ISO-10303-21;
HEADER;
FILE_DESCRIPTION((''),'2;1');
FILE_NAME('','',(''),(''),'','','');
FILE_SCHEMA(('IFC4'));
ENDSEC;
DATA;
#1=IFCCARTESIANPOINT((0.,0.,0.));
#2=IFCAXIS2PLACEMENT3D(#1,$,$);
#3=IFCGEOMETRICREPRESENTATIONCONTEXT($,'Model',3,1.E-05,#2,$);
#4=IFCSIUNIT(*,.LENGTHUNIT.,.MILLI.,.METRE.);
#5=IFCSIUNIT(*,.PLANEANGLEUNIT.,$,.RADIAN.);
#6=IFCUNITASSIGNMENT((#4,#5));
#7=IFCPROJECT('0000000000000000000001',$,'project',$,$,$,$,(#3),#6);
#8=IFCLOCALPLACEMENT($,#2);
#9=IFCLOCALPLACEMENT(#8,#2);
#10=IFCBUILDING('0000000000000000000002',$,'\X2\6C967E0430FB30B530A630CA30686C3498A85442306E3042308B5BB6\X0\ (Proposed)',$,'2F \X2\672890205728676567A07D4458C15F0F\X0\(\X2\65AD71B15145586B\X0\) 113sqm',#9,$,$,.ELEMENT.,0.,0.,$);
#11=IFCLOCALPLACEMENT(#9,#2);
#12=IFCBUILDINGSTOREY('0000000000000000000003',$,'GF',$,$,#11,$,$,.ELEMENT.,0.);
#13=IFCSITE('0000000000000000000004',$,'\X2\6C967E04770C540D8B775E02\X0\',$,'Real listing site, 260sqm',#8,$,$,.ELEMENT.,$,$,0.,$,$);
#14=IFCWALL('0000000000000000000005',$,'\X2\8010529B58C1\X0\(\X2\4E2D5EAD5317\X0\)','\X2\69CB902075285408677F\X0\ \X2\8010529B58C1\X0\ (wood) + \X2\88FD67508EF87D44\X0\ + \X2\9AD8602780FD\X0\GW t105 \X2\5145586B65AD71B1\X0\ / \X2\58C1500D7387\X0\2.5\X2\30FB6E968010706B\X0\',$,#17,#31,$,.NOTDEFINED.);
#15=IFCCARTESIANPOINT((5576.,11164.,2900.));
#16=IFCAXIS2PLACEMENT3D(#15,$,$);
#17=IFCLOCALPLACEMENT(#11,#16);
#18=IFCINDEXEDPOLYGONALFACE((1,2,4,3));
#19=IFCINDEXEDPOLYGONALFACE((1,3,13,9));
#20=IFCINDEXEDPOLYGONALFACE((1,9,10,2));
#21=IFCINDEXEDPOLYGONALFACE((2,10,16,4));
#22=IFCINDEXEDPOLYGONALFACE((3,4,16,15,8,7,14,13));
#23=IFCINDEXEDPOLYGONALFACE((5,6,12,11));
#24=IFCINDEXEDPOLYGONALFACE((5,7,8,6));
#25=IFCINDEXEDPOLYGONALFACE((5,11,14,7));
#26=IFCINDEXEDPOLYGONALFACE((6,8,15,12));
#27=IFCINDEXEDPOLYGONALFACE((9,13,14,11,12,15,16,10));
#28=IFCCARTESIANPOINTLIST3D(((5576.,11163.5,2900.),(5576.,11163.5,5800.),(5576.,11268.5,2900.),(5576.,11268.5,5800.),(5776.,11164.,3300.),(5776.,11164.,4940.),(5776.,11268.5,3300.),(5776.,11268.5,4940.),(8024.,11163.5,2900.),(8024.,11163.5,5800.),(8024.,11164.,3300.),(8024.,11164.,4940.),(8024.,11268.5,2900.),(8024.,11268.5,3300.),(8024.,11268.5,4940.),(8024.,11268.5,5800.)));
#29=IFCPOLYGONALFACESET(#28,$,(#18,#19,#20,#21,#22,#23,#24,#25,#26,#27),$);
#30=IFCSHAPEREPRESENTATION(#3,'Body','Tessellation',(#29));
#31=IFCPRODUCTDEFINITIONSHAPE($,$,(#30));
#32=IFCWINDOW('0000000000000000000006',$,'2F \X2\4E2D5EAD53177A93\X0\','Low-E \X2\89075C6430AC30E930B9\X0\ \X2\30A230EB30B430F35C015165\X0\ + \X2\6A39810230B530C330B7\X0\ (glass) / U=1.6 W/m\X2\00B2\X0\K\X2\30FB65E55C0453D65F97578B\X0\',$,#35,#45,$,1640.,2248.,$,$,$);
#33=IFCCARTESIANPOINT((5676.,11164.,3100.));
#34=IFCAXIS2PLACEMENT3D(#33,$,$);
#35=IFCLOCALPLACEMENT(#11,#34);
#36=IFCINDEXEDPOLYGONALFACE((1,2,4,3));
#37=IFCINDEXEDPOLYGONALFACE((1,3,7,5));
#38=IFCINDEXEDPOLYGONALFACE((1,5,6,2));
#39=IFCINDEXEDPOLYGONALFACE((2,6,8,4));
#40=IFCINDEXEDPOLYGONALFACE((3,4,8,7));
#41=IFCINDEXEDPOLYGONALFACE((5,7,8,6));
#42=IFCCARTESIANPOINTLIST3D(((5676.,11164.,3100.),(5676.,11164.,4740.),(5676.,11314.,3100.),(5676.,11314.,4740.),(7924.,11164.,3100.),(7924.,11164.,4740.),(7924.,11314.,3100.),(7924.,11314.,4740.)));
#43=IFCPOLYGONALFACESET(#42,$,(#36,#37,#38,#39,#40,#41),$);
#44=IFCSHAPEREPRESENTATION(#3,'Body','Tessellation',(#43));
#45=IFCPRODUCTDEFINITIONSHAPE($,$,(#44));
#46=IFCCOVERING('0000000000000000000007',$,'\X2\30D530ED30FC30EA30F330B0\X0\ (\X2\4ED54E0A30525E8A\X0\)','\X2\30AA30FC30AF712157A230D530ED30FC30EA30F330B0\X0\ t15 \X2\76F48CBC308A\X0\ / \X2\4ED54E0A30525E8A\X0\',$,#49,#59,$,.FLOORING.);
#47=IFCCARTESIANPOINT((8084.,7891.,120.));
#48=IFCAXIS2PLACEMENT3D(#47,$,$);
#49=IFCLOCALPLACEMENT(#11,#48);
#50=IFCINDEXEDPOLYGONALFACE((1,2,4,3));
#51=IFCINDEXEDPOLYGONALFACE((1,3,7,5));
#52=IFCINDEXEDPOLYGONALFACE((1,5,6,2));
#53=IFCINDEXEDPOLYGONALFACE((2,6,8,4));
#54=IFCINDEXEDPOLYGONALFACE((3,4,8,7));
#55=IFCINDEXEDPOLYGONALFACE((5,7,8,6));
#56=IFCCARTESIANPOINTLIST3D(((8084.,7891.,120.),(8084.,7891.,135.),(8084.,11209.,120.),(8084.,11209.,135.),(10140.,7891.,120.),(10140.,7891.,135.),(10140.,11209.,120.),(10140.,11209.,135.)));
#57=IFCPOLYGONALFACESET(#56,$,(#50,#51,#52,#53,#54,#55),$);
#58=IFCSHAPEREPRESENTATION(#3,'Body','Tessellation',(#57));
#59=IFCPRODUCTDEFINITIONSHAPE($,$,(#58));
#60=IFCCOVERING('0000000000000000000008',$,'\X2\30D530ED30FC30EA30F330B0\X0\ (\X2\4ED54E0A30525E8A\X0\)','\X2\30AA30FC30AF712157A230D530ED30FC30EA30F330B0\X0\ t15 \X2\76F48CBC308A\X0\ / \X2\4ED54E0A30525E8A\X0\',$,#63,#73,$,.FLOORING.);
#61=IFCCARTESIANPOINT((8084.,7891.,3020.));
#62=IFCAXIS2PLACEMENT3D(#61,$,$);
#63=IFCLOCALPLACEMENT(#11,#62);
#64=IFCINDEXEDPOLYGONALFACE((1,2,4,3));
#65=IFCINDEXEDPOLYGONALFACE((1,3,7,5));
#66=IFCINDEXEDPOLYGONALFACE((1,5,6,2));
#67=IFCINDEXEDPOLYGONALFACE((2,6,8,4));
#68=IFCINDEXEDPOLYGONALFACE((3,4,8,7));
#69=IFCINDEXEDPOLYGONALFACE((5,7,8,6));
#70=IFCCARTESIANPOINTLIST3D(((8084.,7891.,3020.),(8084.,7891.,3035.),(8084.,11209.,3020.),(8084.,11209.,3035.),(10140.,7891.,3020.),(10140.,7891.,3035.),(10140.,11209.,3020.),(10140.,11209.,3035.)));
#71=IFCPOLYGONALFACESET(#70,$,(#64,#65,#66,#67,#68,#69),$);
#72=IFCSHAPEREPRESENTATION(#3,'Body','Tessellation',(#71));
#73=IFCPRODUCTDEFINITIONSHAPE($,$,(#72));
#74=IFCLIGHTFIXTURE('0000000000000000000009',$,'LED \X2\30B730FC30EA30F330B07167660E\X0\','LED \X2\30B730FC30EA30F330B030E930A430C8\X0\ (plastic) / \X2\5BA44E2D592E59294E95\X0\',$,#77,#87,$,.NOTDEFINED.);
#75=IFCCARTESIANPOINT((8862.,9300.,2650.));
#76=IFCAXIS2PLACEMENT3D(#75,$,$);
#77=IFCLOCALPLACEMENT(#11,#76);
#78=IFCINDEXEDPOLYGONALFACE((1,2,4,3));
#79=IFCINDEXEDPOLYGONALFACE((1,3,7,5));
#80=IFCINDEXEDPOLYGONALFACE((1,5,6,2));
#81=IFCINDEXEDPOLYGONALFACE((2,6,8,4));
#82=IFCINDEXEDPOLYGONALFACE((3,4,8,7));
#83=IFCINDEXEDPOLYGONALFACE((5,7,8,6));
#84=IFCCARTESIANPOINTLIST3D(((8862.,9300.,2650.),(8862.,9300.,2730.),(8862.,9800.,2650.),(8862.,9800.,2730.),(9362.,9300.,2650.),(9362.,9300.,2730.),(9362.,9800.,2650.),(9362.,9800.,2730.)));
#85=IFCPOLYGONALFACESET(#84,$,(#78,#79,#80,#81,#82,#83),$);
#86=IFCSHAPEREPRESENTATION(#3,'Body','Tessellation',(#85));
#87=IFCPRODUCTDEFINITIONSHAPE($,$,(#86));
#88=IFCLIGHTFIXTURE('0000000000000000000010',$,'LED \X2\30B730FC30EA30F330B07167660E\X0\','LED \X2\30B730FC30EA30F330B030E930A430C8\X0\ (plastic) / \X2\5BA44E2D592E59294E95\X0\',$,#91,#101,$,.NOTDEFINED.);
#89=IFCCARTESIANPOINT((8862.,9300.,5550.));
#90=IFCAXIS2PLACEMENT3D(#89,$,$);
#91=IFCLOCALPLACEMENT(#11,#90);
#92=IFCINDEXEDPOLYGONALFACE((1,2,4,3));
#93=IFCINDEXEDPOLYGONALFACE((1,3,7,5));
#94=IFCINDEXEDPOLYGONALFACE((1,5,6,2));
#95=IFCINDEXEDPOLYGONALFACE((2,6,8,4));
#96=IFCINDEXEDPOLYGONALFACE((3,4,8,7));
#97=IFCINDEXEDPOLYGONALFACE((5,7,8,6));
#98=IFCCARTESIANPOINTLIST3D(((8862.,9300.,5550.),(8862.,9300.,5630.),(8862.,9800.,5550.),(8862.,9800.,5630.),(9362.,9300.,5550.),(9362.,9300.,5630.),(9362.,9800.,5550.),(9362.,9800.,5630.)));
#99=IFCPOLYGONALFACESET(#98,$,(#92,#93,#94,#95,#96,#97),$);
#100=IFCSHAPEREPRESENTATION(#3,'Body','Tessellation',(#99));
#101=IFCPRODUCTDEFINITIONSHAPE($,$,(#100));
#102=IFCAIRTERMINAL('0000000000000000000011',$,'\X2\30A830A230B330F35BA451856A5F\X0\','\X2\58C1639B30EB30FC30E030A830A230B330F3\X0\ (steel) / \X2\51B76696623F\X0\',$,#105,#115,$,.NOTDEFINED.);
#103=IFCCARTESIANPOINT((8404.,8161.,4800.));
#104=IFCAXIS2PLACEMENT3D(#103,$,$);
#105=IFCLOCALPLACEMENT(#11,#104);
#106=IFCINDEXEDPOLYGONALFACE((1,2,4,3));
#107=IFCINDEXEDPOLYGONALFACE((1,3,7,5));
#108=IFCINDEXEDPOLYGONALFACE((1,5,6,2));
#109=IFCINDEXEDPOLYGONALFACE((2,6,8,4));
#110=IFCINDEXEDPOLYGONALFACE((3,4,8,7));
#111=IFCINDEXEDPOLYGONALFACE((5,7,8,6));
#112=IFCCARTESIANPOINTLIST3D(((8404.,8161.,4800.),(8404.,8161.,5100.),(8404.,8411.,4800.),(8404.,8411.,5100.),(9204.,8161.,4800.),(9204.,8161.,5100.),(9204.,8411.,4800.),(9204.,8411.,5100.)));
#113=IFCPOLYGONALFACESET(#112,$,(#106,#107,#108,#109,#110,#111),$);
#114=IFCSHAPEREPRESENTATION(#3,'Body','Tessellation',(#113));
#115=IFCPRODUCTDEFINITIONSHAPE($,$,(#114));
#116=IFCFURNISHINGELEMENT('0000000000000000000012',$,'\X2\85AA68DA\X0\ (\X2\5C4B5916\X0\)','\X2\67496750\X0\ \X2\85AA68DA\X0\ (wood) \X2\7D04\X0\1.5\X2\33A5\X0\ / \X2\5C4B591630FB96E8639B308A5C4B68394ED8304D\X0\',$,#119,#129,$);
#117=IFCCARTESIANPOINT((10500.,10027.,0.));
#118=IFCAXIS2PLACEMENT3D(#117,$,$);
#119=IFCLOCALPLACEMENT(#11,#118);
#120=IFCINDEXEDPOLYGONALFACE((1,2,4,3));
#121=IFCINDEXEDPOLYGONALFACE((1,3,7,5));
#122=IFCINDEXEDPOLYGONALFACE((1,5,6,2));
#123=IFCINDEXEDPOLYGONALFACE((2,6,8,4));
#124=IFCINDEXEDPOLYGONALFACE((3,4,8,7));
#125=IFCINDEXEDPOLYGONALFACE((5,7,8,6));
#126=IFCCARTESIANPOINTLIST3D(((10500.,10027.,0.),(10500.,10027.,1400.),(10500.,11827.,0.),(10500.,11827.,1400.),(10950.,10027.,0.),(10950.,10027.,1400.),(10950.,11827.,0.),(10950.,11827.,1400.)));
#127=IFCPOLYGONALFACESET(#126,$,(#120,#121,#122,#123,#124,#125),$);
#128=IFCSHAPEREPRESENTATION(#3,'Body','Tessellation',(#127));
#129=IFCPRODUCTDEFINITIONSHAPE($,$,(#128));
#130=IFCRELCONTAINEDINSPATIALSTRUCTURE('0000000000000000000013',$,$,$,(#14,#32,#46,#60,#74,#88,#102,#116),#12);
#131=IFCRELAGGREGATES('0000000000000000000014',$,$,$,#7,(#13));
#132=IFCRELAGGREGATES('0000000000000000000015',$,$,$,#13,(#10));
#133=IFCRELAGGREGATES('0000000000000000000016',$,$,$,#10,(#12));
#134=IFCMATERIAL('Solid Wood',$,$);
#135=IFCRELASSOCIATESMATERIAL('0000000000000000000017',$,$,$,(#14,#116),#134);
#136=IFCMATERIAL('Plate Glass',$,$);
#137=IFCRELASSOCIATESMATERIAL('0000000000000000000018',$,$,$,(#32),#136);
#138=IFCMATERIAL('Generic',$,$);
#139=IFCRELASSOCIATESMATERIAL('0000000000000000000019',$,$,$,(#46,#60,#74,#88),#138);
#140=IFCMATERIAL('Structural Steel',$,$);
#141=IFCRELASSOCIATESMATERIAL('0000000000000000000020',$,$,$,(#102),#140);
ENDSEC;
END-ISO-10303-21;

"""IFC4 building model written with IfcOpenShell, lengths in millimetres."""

from ifc_helpers import new_model, si_unit, frame, frame_2d, origin, place, context, project, spatial, rectangle, extrude, material, element, fill, save


model = new_model("IFC4")

# Units and contexts
model_context = context("Model", 3, precision=1e-05, world=origin())
ifc_project = project(units=[si_unit("LENGTHUNIT", "METRE", prefix="MILLI"), si_unit("PLANEANGLEUNIT", "RADIAN")], contexts=[model_context])

# Site, building, storey
site_placement = place(None, origin())
site = spatial("IfcSite", under=ifc_project, at=site_placement, Name="沖縄県名護市", ObjectType="Real listing site, 260sqm", CompositionType="ELEMENT", RefElevation=0.0)
building_placement = place(site_placement, origin())
building = spatial("IfcBuilding", under=site, at=building_placement, Name="沖縄・サウナと水風呂のある家 (Proposed)", ObjectType="2F 木造在来枠組壁式(断熱充填) 113sqm", CompositionType="ELEMENT", ElevationOfRefHeight=0.0, ElevationOfTerrain=0.0)
storey_placement = place(building_placement, origin())
storey = spatial("IfcBuildingStorey", under=building, at=storey_placement, Name="GF", CompositionType="ELEMENT", Elevation=0.0)

# Shared definitions
ifc_material_1 = material(Name="Solid Wood")

# Wall, opening, window
ifc_material_2 = material(Name="Plate Glass")
wall_1_placement = place(storey_placement, frame((5576.0, 11164.0, 2900.0)))
wall_1 = element("IfcWall", 1, at=wall_1_placement, inside=storey, material=ifc_material_1, Name="耐力壁(中庭北)", Description="構造用合板 耐力壁 (wood) + 製材軸組 + 高性能GW t105 充填断熱 / 壁倍率2.5・準耐火", PredefinedType="NOTDEFINED", context=model_context, shape_type="SweptSolid", body=[
    extrude(rectangle(XDim=2448.0, YDim=105.0, at=frame_2d((1224.0, 52.0))), frame((5576.0, 11164.0, 2900.0)), (0.0, 0.0, 1.0), 2900.0),
])
opening_1_placement = place(storey_placement, frame((5676.0, 11164.0, 3100.0)))
opening_1 = element("IfcOpeningElement", 2, at=opening_1_placement, cuts=wall_1, PredefinedType="NOTDEFINED", context=model_context, shape_type="SweptSolid", body=[
    extrude(rectangle(XDim=2248.0, YDim=150.0, at=frame_2d((1124.0, 75.0))), frame((5676.0, 11164.0, 3100.0)), (0.0, 0.0, 1.0), 1640.0),
])
window_1_placement = place(storey_placement, frame((5676.0, 11164.0, 3100.0)))
window_1 = element("IfcWindow", 3, at=window_1_placement, inside=storey, material=ifc_material_2, Name="2F 中庭北窓", Description="Low-E 複層ガラス アルゴン封入 + 樹脂サッシ (glass) / U=1.6 W/m²K・日射取得型", OverallHeight=1640.0, OverallWidth=2248.0, context=model_context, shape_type="SweptSolid", body=[
    extrude(rectangle(XDim=2248.0, YDim=150.0, at=frame_2d((1124.0, 75.0))), frame((5676.0, 11164.0, 3100.0)), (0.0, 0.0, 1.0), 1640.0),
])
fill(opening_1, window_1)

# Coverings
ifc_material_3 = material(Name="Generic")
covering_1_placement = place(storey_placement, frame((8084.0, 7891.0, 120.0)))
element("IfcCovering", 4, at=covering_1_placement, inside=storey, material=ifc_material_3, Name="フローリング (仕上げ床)", Description="オーク無垢フローリング t15 直貼り / 仕上げ床", PredefinedType="FLOORING", context=model_context, shape_type="SweptSolid", body=[
    extrude(rectangle(XDim=2056.0, YDim=3318.0, at=frame_2d((1028.0, 1659.0))), frame((8084.0, 7891.0, 120.0)), (0.0, 0.0, 1.0), 15.0),
])
covering_2_placement = place(storey_placement, frame((8084.0, 7891.0, 3020.0)))
element("IfcCovering", 5, at=covering_2_placement, inside=storey, material=ifc_material_3, Name="フローリング (仕上げ床)", Description="オーク無垢フローリング t15 直貼り / 仕上げ床", PredefinedType="FLOORING", context=model_context, shape_type="SweptSolid", body=[
    extrude(rectangle(XDim=2056.0, YDim=3318.0, at=frame_2d((1028.0, 1659.0))), frame((8084.0, 7891.0, 3020.0)), (0.0, 0.0, 1.0), 15.0),
])

# Light fixtures
light_fixture_1_placement = place(storey_placement, frame((8862.0, 9300.0, 2650.0)))
element("IfcLightFixture", 6, at=light_fixture_1_placement, inside=storey, material=ifc_material_3, Name="LED シーリング照明", Description="LED シーリングライト (plastic) / 室中央天井", PredefinedType="NOTDEFINED", context=model_context, shape_type="SweptSolid", body=[
    extrude(rectangle(XDim=500.0, YDim=500.0, at=frame_2d((250.0, 250.0))), frame((8862.0, 9300.0, 2650.0)), (0.0, 0.0, 1.0), 80.0),
])
light_fixture_2_placement = place(storey_placement, frame((8862.0, 9300.0, 5550.0)))
element("IfcLightFixture", 7, at=light_fixture_2_placement, inside=storey, material=ifc_material_3, Name="LED シーリング照明", Description="LED シーリングライト (plastic) / 室中央天井", PredefinedType="NOTDEFINED", context=model_context, shape_type="SweptSolid", body=[
    extrude(rectangle(XDim=500.0, YDim=500.0, at=frame_2d((250.0, 250.0))), frame((8862.0, 9300.0, 5550.0)), (0.0, 0.0, 1.0), 80.0),
])

# Air terminal
ifc_material_4 = material(Name="Structural Steel")
air_terminal_placement = place(storey_placement, frame((8404.0, 8161.0, 4800.0)))
element("IfcAirTerminal", 8, at=air_terminal_placement, inside=storey, material=ifc_material_4, Name="エアコン室内機", Description="壁掛ルームエアコン (steel) / 冷暖房", PredefinedType="NOTDEFINED", context=model_context, shape_type="SweptSolid", body=[
    extrude(rectangle(XDim=800.0, YDim=250.0, at=frame_2d((400.0, 125.0))), frame((8404.0, 8161.0, 4800.0)), (0.0, 0.0, 1.0), 300.0),
])

# Furnishing element
furnishing_placement = place(storey_placement, frame((10500.0, 10027.0, 0.0)))
element("IfcFurnishingElement", 9, at=furnishing_placement, inside=storey, material=ifc_material_1, Name="薪棚 (屋外)", Description="杉材 薪棚 (wood) 約1.5㎥ / 屋外・雨掛り屋根付き", context=model_context, shape_type="SweptSolid", body=[
    extrude(rectangle(XDim=450.0, YDim=1800.0, at=frame_2d((225.0, 900.0))), frame((10500.0, 10027.0, 0.0)), (0.0, 0.0, 1.0), 1400.0),
])

save(model, "model.ifc")
